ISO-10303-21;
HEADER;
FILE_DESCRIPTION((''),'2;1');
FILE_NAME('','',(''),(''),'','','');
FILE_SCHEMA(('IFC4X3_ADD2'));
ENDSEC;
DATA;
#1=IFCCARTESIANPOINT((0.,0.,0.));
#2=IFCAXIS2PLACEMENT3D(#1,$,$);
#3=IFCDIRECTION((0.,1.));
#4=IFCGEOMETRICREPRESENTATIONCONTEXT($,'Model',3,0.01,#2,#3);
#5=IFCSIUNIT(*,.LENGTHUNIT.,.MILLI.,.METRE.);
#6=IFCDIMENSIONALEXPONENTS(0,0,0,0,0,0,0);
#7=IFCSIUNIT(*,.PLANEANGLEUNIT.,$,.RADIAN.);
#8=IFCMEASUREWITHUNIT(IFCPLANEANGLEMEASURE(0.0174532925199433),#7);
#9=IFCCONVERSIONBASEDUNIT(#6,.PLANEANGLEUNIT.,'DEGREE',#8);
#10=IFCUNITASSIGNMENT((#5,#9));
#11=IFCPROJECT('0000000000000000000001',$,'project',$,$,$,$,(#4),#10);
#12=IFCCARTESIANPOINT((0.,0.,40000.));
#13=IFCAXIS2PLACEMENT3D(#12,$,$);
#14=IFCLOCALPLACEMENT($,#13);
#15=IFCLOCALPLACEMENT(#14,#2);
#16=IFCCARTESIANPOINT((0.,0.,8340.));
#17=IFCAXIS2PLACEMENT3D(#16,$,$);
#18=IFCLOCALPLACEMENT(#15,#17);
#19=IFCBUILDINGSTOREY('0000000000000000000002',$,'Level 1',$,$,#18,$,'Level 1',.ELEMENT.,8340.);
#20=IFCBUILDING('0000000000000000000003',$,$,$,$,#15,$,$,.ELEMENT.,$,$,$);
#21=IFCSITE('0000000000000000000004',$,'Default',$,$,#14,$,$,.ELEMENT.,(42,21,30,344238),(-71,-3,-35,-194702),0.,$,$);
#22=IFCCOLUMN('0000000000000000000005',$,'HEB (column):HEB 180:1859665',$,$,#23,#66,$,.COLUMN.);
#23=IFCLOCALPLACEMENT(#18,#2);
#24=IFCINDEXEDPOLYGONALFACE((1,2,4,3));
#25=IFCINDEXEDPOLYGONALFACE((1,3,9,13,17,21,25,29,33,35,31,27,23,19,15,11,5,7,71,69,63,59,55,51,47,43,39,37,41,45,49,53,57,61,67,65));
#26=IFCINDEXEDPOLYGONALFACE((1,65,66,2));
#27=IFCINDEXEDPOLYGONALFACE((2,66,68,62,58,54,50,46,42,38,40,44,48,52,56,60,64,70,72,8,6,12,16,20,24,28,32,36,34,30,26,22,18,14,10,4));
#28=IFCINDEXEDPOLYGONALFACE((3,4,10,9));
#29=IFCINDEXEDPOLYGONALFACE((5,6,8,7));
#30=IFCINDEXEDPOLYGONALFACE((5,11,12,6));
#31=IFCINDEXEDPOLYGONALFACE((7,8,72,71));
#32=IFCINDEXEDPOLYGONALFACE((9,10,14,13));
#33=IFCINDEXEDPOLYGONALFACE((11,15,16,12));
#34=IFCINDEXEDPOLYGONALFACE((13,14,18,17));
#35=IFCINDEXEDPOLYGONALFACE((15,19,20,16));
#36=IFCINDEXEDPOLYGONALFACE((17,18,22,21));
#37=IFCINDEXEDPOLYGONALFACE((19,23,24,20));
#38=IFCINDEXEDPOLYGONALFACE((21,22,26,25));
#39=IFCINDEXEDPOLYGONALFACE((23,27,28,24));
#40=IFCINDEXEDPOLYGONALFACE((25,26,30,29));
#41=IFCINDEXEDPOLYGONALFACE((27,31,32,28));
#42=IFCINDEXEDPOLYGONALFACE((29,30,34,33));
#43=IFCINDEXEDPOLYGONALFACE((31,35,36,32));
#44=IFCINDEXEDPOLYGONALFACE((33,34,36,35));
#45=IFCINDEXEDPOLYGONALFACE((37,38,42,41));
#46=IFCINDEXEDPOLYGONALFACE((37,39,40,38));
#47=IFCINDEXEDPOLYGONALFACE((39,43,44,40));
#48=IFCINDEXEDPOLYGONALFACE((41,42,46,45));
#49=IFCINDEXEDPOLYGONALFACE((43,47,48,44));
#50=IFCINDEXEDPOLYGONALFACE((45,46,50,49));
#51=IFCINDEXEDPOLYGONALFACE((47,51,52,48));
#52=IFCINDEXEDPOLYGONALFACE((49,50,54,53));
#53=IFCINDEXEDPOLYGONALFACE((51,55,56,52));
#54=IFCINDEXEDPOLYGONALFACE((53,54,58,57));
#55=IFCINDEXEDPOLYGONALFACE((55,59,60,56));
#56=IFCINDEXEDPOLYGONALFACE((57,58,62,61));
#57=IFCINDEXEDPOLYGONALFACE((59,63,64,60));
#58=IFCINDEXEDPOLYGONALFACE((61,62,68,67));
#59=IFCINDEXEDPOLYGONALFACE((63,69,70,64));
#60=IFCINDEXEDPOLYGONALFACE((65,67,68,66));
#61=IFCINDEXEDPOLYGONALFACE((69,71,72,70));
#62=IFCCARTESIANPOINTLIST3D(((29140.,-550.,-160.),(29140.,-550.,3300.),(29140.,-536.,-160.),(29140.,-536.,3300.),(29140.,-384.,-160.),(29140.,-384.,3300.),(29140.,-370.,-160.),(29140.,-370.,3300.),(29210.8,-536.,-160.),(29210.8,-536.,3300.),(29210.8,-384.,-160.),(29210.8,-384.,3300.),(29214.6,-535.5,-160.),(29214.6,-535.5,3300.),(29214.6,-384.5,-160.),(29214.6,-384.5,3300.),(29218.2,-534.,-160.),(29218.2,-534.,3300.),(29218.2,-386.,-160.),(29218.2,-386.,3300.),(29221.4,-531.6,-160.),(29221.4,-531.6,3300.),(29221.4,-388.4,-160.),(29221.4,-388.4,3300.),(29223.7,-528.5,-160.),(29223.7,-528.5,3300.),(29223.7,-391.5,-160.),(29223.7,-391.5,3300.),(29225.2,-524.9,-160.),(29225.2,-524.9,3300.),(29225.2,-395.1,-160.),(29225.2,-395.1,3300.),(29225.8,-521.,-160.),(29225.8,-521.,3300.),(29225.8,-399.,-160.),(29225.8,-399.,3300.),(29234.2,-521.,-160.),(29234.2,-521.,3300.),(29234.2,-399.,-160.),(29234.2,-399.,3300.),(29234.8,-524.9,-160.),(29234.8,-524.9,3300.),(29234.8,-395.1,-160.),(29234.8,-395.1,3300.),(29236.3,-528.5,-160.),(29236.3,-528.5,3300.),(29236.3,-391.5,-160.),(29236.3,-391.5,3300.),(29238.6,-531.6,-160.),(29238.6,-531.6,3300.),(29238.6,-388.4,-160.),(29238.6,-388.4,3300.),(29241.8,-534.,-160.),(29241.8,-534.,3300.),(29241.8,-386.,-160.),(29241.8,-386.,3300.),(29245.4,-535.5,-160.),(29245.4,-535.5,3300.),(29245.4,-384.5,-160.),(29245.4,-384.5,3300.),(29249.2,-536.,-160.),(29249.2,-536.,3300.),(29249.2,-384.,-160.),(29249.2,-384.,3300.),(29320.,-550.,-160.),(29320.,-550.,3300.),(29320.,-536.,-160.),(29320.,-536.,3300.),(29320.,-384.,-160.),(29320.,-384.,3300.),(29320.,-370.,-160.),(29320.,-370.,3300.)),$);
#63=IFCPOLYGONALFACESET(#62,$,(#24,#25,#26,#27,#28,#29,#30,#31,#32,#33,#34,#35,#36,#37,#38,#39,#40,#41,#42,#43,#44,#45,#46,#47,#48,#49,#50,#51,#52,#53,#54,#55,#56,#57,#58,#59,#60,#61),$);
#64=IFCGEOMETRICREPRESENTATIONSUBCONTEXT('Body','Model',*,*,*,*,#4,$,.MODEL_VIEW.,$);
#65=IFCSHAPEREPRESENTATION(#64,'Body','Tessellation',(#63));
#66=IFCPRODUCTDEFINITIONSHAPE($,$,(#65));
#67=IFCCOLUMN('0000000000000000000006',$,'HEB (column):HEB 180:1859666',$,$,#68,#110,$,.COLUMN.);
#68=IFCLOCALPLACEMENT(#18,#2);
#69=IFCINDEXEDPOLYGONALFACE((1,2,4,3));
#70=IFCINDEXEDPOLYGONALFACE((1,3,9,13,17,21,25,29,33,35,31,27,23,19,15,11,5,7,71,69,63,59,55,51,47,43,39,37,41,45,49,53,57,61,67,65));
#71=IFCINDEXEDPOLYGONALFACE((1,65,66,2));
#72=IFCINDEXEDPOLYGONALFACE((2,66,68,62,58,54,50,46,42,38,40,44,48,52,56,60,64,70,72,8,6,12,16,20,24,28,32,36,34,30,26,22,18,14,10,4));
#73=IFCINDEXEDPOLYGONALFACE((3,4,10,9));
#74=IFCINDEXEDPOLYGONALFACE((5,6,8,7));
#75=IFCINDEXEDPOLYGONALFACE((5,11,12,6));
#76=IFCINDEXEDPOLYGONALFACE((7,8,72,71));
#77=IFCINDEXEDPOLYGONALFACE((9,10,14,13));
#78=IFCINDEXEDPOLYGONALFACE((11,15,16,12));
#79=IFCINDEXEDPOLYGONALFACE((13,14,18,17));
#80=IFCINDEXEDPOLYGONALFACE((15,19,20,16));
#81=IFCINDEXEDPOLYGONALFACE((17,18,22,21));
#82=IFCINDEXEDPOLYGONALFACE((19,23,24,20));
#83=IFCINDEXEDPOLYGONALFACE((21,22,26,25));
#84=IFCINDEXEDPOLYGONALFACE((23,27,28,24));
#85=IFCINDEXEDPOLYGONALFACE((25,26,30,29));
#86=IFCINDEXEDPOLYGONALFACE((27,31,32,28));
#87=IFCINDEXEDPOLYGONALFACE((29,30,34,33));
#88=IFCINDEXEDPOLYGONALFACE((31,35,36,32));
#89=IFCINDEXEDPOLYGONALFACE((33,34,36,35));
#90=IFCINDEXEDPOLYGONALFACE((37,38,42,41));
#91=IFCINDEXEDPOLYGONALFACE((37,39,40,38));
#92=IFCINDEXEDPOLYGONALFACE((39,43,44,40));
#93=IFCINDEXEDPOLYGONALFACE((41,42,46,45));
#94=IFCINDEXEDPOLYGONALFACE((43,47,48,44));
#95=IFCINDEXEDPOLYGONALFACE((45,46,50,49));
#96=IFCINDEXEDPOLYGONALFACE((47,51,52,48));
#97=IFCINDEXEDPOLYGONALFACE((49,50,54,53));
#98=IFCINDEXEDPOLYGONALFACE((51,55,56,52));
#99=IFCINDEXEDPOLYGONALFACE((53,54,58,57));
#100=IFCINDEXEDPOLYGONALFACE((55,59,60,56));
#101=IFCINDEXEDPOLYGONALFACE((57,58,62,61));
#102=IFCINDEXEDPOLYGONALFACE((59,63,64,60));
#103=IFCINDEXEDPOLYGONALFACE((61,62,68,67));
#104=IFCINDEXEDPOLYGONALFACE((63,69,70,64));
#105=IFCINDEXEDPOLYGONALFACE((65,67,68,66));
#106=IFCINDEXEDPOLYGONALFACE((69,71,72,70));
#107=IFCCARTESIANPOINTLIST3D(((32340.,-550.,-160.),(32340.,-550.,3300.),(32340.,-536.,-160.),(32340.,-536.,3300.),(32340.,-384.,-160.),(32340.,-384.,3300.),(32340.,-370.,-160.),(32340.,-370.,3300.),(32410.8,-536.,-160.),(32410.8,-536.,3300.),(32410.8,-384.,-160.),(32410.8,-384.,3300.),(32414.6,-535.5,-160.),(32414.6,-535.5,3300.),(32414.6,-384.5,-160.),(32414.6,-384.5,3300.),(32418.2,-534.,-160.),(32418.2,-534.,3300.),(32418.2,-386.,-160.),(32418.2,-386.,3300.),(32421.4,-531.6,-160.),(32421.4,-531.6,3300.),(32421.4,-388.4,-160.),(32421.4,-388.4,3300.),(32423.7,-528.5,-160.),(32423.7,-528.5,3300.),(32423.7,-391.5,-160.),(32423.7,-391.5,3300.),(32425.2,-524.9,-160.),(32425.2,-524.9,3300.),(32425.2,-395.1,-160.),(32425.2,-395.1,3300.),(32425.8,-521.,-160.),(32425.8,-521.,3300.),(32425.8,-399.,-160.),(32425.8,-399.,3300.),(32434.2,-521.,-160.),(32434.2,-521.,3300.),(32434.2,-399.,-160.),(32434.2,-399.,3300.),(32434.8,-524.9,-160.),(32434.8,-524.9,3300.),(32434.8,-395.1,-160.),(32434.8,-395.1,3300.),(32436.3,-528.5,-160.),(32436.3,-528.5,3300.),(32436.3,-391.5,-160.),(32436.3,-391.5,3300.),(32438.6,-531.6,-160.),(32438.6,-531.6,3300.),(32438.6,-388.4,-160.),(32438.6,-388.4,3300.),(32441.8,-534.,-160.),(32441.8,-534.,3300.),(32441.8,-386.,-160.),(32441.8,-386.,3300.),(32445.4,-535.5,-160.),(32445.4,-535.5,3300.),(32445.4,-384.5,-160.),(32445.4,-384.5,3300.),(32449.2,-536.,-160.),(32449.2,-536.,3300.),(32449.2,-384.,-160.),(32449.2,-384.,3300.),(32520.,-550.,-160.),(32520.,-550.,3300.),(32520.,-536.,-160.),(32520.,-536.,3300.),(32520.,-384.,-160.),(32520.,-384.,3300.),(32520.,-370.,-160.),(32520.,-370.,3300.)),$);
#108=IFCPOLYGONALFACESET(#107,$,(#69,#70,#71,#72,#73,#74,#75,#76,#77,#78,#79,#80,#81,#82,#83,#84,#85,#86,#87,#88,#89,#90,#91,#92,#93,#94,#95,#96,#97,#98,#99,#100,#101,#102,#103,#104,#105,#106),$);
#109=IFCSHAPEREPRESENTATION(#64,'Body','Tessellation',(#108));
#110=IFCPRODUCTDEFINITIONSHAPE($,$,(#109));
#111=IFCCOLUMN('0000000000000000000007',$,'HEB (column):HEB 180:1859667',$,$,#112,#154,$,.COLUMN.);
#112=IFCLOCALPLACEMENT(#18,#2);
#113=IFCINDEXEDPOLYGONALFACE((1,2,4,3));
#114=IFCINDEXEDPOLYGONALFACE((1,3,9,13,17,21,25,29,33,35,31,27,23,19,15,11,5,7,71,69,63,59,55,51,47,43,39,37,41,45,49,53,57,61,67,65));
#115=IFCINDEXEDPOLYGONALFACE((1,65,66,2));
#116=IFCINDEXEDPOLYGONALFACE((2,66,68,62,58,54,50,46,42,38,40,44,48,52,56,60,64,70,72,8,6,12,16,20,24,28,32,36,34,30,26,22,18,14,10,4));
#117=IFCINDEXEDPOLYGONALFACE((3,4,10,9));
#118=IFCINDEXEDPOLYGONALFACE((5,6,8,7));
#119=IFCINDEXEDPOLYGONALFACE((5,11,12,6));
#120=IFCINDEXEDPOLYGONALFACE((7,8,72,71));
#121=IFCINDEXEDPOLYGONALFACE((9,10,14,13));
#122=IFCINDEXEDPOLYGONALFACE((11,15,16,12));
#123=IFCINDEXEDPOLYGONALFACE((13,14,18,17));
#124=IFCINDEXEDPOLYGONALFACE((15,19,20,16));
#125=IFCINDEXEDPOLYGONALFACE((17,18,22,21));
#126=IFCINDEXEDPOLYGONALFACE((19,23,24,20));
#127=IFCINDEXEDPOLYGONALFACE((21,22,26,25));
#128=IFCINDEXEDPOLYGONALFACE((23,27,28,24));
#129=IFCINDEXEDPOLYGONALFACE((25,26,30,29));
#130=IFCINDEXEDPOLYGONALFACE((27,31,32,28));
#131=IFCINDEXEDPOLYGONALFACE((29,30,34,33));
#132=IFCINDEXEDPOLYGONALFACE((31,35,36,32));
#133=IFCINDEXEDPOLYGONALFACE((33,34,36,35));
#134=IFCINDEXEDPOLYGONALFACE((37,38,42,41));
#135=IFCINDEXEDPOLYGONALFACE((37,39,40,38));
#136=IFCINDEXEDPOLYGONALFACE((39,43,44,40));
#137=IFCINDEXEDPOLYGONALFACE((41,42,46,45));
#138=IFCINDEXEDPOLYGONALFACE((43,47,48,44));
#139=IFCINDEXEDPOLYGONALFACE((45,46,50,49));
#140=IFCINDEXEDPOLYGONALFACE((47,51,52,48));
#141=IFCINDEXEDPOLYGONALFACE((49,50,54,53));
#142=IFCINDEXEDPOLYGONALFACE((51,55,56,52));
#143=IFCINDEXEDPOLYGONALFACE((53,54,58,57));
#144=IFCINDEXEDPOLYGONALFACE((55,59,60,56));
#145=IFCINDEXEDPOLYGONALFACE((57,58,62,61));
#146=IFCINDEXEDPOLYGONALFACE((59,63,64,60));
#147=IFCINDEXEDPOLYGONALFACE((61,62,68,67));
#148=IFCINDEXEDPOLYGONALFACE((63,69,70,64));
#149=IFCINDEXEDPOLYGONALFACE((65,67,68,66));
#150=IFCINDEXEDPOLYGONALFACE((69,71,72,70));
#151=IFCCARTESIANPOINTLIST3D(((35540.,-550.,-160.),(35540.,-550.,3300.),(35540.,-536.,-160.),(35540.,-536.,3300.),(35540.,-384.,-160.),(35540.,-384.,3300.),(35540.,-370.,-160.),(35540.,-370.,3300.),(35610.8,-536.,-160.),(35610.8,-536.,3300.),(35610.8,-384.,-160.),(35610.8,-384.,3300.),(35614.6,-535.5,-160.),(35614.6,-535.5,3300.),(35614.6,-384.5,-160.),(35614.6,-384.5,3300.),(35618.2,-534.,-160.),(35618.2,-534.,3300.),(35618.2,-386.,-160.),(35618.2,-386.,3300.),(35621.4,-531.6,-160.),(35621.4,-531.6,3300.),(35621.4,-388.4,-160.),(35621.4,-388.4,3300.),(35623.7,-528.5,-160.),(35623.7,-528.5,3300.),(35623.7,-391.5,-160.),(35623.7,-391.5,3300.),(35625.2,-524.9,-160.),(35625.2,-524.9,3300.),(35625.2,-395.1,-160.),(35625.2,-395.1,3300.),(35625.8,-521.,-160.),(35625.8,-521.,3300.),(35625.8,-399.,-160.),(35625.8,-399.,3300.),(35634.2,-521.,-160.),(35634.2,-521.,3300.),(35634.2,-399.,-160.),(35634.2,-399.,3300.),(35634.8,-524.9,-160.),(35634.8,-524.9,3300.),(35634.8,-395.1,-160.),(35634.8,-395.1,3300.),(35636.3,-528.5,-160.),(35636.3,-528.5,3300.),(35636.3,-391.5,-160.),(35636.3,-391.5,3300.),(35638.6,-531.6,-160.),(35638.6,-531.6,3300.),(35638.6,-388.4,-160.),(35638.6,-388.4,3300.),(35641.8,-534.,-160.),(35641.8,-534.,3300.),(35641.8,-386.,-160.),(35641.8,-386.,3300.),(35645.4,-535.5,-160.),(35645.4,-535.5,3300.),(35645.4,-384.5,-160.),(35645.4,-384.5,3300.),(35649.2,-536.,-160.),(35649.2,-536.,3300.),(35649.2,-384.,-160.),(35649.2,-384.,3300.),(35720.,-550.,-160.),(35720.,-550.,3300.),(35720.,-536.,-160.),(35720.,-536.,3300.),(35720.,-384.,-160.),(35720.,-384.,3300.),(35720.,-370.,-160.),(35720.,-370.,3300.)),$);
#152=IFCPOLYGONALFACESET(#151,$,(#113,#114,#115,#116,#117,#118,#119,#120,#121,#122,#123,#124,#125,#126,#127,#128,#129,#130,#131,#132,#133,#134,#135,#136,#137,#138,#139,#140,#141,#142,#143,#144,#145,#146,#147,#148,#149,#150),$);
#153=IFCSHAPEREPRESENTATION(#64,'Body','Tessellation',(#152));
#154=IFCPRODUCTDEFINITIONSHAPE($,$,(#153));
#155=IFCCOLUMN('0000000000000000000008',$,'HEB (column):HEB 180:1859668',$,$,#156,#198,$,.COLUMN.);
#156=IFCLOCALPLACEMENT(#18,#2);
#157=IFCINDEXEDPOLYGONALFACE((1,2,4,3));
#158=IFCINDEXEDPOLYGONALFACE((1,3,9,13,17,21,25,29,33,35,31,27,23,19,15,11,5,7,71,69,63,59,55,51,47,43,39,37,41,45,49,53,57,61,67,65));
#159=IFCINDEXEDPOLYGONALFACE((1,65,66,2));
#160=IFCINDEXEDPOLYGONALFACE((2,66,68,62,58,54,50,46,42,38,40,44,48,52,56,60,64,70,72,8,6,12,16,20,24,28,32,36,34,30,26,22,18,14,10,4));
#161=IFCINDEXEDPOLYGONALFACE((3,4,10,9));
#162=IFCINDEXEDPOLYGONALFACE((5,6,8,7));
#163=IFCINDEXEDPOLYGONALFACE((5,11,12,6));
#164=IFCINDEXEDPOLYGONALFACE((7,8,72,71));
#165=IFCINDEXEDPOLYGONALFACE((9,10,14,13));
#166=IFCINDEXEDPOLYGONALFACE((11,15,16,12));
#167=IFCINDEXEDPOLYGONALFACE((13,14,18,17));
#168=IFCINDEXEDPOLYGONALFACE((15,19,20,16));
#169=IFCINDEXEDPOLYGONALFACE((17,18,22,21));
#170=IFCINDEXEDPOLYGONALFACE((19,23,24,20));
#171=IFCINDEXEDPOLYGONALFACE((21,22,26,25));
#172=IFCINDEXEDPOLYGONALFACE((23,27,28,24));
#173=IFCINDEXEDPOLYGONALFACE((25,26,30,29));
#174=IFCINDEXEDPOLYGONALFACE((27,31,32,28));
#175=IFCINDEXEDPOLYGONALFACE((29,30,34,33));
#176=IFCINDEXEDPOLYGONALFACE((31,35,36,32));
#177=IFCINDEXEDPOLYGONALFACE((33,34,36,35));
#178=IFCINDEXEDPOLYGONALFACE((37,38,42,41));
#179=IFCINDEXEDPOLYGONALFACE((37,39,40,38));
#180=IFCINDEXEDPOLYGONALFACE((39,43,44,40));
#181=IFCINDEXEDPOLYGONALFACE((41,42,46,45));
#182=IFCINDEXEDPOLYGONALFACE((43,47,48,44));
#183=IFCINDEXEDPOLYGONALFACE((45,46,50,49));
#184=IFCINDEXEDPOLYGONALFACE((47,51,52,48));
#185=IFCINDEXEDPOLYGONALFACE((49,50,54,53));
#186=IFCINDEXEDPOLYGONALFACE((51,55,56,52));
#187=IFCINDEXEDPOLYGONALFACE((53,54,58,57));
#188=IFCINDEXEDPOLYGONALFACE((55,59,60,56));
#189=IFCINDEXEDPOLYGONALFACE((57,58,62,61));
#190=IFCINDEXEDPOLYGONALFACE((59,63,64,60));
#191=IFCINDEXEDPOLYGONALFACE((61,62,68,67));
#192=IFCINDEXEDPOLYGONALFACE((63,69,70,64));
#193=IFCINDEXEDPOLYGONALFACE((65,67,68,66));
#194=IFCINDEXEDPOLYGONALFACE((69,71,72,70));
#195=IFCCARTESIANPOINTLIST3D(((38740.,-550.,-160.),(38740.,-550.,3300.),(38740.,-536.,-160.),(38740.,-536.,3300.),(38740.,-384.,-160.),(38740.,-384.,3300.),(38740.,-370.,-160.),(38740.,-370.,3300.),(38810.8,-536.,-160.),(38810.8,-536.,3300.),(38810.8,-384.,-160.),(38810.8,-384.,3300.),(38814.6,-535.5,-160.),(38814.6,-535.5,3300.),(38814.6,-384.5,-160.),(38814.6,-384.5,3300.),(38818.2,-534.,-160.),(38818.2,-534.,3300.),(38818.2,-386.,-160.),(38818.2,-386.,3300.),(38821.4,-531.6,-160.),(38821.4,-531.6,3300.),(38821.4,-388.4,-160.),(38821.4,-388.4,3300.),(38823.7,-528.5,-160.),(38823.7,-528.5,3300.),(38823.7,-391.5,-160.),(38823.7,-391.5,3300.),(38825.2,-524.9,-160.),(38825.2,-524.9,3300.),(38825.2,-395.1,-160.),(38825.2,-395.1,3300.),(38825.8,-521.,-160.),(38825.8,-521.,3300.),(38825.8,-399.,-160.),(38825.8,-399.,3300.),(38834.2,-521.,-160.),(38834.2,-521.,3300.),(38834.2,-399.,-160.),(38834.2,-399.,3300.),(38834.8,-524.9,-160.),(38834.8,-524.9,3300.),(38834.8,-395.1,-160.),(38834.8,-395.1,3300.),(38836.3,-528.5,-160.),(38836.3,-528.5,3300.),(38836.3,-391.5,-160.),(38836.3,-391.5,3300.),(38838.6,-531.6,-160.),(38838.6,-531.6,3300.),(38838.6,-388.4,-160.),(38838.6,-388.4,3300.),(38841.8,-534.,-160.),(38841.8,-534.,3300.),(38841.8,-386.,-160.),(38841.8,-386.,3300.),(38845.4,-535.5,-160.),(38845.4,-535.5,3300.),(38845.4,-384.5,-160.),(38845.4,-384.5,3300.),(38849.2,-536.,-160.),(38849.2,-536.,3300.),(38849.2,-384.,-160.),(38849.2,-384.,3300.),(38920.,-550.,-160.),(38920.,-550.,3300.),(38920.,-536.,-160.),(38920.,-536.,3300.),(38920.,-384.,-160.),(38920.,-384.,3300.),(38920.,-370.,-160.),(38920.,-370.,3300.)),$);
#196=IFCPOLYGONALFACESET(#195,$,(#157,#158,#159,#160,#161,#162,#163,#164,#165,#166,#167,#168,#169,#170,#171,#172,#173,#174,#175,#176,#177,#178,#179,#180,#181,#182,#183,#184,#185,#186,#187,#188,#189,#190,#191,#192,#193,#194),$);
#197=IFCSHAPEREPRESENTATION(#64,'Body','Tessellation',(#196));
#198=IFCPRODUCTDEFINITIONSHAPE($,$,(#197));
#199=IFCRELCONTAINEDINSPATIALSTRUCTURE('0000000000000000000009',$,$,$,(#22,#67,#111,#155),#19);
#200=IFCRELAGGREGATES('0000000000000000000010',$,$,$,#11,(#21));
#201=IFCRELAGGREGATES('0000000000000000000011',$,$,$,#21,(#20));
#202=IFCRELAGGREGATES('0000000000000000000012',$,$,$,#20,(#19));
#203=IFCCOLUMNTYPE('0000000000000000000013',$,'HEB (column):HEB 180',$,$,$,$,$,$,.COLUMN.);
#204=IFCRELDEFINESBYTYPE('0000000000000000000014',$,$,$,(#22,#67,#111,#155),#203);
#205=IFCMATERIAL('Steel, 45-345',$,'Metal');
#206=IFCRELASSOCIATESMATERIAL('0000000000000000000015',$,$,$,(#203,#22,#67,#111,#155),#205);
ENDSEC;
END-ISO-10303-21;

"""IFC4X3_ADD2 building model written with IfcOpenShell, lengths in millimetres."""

from ifc_helpers import new_model, entity, si_unit, converted_unit, direction, frame, origin, origin_2d_with_axis, place, context, subcontext, project, spatial, i_section, extrude, source, transform, mapped, material, material_profile, profile_set, profile_usage, type_object, type_shapes, element, save


model = new_model("IFC4X3_ADD2")

# Units and contexts
model_context = context("Model", 3, precision=0.01, world=origin(), true_north=direction((0.0, 1.0)))
body_context = subcontext(model_context, "Body", "Model", "MODEL_VIEW")
ifc_project = project(units=[si_unit("LENGTHUNIT", "METRE", prefix="MILLI"), converted_unit("PLANEANGLEUNIT", "DEGREE", entity("IfcPlaneAngleMeasure", 0.0174532925199433), si_unit("PLANEANGLEUNIT", "RADIAN"), dimensions=[0, 0, 0, 0, 0, 0, 0])], contexts=[model_context])

# Site, building, storey
site_placement = place(None, frame((0.0, 0.0, 40000.0)))
site = spatial("IfcSite", under=ifc_project, at=site_placement, Name="Default", CompositionType="ELEMENT", RefLatitude=(42, 21, 30, 344238), RefLongitude=(-71, -3, -35, -194702), RefElevation=0.0)
building_placement = place(site_placement, origin())
building = spatial("IfcBuilding", under=site, at=building_placement, CompositionType="ELEMENT")
storey_placement = place(building_placement, frame((0.0, 0.0, 8340.0)))
storey = spatial("IfcBuildingStorey", under=building, at=storey_placement, Name="Level 1", LongName="Level 1", CompositionType="ELEMENT", Elevation=8340.0)

# Columns
ifc_material = material(Name="Steel, 45-345", Category="Metal")
ifc_material_profile_1 = material_profile(ifc_material, i_section(OverallWidth=180.0, OverallDepth=180.0, WebThickness=8.5, FlangeThickness=14.0, FilletRadius=15.0, at=origin_2d_with_axis()), Name="HEB 180")
ifc_profile_set_1 = profile_set([ifc_material_profile_1], Name="HEB 180")
ifc_profile_usage_1 = profile_usage(ifc_profile_set_1)
column_type_1 = type_object("IfcColumnType", Name="HEB (column):HEB 180", PredefinedType="COLUMN", material=ifc_profile_set_1)
shared_shape_1 = source(origin(), body_context, "Body", "SweptSolid", [
    extrude(i_section(OverallWidth=180.0, OverallDepth=180.0, WebThickness=8.5, FlangeThickness=14.0, FilletRadius=15.0, at=origin_2d_with_axis()), frame((0.0, 0.0, 8180.0), z_axis=(0.0, 0.0, 1.0), x_axis=(-1.0, 0.0, 0.0)), (0.0, 0.0, 1.0), 3460.0),
])
type_shapes(column_type_1, [shared_shape_1])
for number, where, name in (
    (1, (29230.0, -460.0, -8340.0), "HEB (column):HEB 180:1859665"),
    (2, (32430.0, -460.0, -8340.0), "HEB (column):HEB 180:1859666"),
    (3, (35630.0, -460.0, -8340.0), "HEB (column):HEB 180:1859667"),
    (4, (38830.0, -460.0, -8340.0), "HEB (column):HEB 180:1859668"),
):
    element("IfcColumn", number, at=place(storey_placement, frame(where)), inside=storey, type_object=column_type_1, material=ifc_profile_usage_1, Name=name, PredefinedType="COLUMN", context=body_context, shape_type="MappedRepresentation", body=[
        mapped(shared_shape_1, transform((0.0, 0.0, 0.0), scale=1.0)),
    ])

save(model, "model.ifc")
